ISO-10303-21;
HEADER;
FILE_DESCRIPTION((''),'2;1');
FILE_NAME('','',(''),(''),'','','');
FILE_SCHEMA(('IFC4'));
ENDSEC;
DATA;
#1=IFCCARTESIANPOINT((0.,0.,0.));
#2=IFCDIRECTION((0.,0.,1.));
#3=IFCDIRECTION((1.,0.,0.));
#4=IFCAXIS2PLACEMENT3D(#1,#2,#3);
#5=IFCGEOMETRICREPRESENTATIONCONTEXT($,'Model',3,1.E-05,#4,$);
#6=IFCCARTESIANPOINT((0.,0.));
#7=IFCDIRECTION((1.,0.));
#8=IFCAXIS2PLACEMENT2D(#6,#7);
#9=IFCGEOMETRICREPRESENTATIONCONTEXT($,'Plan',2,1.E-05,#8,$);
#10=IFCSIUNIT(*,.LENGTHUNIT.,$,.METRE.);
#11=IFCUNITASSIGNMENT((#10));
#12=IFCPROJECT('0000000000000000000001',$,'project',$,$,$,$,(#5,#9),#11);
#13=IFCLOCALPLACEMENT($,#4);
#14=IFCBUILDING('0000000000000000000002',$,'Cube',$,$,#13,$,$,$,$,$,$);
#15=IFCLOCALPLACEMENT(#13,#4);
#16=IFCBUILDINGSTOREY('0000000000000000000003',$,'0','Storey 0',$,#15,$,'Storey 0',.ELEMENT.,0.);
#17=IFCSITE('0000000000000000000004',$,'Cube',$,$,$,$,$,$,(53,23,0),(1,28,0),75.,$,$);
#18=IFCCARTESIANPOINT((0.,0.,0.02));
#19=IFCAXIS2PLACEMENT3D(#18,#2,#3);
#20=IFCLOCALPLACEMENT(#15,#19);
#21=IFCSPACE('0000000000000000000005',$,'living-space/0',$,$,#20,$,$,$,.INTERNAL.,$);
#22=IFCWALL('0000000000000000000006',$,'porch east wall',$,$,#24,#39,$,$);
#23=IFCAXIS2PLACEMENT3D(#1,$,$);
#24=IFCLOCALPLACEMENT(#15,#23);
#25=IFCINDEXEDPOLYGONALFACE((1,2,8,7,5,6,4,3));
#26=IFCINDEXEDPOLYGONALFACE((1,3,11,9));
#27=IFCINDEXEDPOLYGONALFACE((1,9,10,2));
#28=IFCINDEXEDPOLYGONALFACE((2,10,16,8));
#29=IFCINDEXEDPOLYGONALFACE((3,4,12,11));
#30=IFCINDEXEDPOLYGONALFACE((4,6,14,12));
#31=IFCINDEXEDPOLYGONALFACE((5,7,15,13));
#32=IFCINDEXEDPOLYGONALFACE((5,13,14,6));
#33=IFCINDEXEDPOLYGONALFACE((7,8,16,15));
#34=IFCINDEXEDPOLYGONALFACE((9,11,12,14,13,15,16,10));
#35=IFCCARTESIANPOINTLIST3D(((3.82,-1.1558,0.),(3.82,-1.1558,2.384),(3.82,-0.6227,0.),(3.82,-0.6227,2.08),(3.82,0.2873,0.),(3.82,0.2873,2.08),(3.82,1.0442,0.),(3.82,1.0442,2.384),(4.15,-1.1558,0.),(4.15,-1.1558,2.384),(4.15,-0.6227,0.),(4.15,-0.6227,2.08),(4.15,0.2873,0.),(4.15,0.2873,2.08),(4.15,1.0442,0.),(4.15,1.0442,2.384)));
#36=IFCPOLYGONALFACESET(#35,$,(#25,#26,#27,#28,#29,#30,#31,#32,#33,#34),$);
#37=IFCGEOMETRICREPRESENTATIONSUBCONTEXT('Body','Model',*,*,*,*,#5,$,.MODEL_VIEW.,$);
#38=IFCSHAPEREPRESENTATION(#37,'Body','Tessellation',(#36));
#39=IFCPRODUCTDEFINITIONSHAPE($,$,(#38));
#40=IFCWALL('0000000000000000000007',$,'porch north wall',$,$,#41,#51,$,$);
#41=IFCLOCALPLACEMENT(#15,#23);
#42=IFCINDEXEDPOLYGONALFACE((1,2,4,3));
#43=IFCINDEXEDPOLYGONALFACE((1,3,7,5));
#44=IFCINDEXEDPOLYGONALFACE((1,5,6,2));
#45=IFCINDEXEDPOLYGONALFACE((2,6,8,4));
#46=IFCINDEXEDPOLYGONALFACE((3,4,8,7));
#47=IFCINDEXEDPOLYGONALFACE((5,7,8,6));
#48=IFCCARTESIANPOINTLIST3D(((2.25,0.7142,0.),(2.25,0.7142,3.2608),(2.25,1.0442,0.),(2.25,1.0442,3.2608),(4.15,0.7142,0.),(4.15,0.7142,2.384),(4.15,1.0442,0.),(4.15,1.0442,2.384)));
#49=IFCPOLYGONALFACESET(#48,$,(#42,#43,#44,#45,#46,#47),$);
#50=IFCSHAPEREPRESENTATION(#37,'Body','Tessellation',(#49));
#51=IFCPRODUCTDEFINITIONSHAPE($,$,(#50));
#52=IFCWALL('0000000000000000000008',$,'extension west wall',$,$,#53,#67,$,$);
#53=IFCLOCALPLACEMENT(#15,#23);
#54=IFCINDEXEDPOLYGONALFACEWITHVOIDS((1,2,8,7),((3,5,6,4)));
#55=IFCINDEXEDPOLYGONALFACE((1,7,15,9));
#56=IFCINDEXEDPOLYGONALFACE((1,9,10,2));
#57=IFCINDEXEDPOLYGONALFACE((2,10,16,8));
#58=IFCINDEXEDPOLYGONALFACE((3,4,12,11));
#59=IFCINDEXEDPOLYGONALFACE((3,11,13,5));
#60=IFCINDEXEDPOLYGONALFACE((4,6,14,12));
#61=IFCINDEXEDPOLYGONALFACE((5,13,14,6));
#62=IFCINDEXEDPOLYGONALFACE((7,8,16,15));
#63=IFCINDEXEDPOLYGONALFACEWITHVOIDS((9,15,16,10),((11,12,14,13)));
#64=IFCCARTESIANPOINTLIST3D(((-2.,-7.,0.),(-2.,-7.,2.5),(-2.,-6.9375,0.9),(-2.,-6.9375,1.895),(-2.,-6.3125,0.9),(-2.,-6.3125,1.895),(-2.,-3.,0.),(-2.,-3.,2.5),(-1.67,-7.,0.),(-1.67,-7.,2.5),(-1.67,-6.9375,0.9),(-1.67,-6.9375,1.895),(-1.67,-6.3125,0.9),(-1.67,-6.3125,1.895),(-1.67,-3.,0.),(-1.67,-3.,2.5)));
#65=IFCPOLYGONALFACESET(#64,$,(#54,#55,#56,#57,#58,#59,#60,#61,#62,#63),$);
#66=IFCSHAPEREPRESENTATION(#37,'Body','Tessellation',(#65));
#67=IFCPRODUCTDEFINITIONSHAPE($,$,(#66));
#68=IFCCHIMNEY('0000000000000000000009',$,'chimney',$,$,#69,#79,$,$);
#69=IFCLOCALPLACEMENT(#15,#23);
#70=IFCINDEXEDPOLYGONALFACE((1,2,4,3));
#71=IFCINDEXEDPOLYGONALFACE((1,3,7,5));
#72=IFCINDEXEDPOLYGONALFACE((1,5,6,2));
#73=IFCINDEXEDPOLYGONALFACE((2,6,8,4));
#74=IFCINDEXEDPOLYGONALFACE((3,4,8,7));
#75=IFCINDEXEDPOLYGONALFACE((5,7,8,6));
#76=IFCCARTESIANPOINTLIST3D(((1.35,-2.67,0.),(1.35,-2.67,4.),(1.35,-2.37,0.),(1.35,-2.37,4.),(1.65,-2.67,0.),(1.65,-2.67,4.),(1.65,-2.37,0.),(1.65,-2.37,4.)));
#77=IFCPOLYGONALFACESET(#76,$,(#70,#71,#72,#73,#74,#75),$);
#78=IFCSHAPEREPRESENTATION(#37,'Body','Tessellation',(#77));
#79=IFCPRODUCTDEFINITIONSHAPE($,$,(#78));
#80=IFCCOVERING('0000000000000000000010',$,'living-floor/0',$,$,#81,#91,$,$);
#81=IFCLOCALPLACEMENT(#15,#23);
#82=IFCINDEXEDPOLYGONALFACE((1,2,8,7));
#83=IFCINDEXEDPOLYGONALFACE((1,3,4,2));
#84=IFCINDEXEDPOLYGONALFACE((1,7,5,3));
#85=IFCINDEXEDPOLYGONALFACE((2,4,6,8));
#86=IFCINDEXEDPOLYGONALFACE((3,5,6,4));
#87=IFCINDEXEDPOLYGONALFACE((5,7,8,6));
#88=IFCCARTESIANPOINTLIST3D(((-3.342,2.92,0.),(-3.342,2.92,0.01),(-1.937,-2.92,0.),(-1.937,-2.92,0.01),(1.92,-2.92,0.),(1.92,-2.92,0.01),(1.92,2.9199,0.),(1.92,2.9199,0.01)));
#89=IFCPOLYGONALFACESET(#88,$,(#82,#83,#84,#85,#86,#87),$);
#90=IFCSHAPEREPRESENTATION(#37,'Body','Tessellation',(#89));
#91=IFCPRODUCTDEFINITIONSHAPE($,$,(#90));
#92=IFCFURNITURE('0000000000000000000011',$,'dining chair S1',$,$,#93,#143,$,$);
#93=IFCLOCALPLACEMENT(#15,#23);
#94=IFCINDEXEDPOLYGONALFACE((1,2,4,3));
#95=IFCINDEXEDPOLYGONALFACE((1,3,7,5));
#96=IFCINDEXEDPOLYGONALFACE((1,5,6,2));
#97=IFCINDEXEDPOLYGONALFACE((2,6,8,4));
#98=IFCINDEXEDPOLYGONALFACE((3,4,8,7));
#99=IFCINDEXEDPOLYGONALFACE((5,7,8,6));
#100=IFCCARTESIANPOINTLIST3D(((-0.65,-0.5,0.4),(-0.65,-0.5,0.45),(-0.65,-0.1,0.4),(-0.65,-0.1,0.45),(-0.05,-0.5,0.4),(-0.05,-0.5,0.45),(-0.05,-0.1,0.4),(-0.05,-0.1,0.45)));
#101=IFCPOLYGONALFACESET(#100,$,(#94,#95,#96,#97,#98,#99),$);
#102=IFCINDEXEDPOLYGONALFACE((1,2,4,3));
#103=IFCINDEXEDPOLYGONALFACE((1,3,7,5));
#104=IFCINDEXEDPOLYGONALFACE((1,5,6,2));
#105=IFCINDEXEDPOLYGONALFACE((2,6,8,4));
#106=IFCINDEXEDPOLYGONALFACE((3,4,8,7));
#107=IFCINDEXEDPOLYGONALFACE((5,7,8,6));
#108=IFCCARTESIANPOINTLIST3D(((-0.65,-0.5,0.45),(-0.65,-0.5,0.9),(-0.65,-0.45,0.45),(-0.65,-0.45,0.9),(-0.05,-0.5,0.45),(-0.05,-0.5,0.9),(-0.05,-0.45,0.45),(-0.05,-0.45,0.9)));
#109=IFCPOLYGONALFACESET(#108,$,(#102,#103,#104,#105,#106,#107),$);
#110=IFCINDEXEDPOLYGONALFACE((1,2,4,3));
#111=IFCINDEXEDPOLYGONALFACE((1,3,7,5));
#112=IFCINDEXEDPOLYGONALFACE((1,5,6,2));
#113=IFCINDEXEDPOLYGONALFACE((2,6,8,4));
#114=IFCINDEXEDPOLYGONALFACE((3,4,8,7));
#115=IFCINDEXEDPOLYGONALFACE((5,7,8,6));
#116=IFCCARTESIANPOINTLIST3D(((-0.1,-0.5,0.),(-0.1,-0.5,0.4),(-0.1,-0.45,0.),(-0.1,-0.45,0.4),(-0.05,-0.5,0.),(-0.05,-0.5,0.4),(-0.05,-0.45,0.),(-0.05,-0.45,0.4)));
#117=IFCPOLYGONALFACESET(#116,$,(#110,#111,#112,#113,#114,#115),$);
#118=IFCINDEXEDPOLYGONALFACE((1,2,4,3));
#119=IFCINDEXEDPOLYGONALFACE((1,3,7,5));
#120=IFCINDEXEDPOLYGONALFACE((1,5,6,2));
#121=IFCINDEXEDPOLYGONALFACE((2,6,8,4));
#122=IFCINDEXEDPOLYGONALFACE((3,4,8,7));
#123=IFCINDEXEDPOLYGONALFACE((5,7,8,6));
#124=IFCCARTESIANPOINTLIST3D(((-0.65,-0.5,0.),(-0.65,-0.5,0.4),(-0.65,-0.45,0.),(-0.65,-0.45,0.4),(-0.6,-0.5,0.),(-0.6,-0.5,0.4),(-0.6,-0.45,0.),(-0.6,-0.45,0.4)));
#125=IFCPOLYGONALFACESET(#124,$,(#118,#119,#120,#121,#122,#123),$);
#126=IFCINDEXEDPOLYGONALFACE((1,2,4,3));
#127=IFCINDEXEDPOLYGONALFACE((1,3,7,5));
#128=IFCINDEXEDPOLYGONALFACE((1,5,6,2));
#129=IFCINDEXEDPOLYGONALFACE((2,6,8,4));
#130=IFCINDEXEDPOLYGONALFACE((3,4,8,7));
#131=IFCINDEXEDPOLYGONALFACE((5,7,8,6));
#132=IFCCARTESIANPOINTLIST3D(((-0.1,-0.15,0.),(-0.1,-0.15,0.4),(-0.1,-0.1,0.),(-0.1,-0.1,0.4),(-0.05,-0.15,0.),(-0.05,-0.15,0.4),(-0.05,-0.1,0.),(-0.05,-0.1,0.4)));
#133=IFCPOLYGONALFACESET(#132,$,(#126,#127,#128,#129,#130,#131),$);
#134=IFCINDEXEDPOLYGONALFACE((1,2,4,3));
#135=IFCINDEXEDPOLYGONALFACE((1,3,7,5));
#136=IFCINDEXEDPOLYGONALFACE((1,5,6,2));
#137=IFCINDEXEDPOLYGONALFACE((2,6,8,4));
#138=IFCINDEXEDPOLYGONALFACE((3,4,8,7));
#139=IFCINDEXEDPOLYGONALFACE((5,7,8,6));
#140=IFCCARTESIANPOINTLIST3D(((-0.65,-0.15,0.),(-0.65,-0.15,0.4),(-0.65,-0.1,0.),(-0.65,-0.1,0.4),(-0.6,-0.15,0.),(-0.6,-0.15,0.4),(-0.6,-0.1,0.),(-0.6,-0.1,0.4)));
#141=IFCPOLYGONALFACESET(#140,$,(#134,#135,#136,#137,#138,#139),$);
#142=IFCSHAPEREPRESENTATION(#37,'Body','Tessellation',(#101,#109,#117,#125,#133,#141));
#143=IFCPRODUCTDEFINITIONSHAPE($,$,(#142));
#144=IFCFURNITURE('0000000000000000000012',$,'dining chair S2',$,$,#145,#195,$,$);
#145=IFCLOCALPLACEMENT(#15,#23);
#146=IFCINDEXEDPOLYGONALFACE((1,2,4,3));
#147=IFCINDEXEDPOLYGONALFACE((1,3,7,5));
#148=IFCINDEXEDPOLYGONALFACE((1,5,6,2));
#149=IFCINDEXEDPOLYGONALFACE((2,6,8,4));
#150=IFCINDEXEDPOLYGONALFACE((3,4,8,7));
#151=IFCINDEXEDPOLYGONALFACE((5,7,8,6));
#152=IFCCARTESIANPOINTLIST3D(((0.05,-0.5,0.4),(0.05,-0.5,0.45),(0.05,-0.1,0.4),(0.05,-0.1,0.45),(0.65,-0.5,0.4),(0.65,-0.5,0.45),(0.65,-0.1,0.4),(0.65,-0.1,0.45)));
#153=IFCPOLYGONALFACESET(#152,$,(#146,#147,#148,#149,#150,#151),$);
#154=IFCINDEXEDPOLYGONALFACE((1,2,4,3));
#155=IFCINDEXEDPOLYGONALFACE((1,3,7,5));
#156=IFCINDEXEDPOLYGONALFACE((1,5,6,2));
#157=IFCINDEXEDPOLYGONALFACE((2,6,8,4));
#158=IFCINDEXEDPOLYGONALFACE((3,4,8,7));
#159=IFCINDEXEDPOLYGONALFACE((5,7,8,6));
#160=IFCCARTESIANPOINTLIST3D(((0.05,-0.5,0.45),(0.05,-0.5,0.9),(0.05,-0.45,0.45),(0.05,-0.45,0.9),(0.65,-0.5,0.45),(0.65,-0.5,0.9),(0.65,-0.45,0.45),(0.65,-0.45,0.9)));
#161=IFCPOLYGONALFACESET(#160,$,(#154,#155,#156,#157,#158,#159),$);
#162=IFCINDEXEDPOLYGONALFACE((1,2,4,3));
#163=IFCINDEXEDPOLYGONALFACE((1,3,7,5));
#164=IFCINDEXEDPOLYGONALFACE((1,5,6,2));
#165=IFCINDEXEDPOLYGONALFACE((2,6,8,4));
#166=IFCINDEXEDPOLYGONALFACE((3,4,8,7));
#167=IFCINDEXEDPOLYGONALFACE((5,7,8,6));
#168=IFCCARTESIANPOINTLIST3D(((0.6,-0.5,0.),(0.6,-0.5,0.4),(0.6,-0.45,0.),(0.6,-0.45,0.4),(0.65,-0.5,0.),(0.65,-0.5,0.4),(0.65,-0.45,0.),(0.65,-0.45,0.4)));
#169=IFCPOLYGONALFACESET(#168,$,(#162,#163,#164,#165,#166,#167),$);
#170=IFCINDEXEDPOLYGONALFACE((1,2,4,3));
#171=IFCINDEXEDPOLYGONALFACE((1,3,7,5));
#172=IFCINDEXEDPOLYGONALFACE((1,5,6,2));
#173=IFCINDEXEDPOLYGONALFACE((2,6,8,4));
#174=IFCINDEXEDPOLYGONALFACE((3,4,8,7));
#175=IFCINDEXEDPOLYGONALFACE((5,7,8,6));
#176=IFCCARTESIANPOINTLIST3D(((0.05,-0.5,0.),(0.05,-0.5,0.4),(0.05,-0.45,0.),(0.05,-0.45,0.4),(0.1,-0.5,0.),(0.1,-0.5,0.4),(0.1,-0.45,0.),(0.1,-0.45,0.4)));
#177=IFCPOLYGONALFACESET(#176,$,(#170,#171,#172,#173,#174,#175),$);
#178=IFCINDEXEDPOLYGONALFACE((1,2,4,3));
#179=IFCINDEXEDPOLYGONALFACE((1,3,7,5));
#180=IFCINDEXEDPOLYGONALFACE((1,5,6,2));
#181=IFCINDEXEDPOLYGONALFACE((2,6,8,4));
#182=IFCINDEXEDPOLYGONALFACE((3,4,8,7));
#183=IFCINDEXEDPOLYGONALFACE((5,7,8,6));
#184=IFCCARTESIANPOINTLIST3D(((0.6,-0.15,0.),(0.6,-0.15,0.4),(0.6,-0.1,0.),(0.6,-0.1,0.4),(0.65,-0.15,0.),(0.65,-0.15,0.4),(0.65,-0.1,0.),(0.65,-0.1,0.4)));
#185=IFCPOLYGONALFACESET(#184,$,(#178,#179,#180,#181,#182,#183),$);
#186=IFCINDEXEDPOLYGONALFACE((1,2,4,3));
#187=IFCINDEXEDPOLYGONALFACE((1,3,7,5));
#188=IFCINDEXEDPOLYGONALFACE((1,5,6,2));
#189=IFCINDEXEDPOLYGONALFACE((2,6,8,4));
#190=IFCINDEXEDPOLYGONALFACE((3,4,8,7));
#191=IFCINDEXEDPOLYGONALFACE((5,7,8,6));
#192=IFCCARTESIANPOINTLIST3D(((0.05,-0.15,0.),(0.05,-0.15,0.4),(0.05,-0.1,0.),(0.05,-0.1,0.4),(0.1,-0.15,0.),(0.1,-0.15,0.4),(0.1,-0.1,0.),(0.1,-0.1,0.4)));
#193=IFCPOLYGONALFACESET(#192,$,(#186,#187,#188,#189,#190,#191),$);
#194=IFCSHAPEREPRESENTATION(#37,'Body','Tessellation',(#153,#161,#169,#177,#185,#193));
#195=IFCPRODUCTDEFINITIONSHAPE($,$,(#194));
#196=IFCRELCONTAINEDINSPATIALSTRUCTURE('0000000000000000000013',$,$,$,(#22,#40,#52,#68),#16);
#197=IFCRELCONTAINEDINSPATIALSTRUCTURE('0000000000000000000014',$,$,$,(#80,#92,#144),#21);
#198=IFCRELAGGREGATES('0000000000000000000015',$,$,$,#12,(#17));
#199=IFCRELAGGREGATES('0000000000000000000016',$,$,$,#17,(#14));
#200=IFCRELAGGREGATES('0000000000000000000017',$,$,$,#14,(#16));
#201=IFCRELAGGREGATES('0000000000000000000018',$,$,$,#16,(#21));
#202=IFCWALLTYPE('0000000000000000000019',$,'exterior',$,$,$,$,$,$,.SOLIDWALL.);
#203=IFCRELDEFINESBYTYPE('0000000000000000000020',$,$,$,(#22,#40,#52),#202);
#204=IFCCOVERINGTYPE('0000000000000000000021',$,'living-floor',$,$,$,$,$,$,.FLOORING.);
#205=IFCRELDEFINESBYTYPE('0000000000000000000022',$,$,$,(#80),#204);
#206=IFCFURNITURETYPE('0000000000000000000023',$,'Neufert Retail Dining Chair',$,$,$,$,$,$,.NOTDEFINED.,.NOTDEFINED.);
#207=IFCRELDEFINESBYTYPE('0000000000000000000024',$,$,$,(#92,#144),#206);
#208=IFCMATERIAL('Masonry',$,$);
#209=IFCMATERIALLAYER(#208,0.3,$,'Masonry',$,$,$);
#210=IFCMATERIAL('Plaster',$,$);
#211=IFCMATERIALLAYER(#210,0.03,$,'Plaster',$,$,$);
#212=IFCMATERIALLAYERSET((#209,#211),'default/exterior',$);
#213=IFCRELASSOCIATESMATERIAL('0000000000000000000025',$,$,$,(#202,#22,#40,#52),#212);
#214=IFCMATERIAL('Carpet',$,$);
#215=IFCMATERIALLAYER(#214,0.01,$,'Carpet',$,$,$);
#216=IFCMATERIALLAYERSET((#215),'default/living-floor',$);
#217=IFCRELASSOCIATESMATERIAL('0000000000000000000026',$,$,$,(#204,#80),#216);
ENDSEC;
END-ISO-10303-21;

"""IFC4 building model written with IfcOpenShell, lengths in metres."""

from ifc_helpers import new_model, entity, si_unit, frame, origin_with_axes, origin_2d_with_axis, place, context, subcontext, project, spatial, polyline, line, indexed_curve, outline, extrude, clip, halfspace, shape, source, transform, mapped, material, layer, layer_set, layer_usage, type_object, type_shapes, element, save


model = new_model("IFC4")

# Units and contexts
model_context = context("Model", 3, precision=1e-05, world=origin_with_axes())
plan_context = context("Plan", 2, precision=1e-05, world=origin_2d_with_axis())
body_context_1 = subcontext(model_context, "Body", "Model", "MODEL_VIEW")
body_context_2 = subcontext(plan_context, "Body", "Plan", "PLAN_VIEW")
ifc_project = project(units=[si_unit("LENGTHUNIT", "METRE")], contexts=[model_context, plan_context])

# Site, building, storey
site = spatial("IfcSite", under=ifc_project, Name="Cube", RefLatitude=(53, 23, 0), RefLongitude=(1, 28, 0), RefElevation=75.0)
building_placement = place(None, origin_with_axes())
building = spatial("IfcBuilding", under=site, at=building_placement, Name="Cube")
storey_placement = place(building_placement, origin_with_axes())
storey = spatial("IfcBuildingStorey", under=building, at=storey_placement, Name="0", Description="Storey 0", LongName="Storey 0", CompositionType="ELEMENT", Elevation=0.0)

# Shared definitions
ifc_material_1 = material(Name="Masonry")
ifc_layer_1 = layer(ifc_material_1, 0.3, Name="Masonry")
ifc_material_2 = material(Name="Plaster")
ifc_layer_2 = layer(ifc_material_2, 0.03, Name="Plaster")
ifc_layer_set_1 = layer_set([ifc_layer_1, ifc_layer_2], Name="default/exterior")
wall_type = type_object("IfcWallType", Name="exterior", PredefinedType="SOLIDWALL", material=ifc_layer_set_1)

# Wall, opening
ifc_layer_usage_1 = layer_usage(ifc_layer_set_1, "AXIS2", "POSITIVE", 0.0)
wall_1_placement = place(storey_placement, frame((4.15, -1.1558, 0.0), z_axis=(0.0, 0.0, 1.0), x_axis=(0.0, 1.0, 0.0)))
wall_1 = element("IfcWall", 1, at=wall_1_placement, inside=storey, type_object=wall_type, material=ifc_layer_usage_1, Name="porch east wall", context=body_context_1, shape_type="SweptSolid", body=[
    extrude(outline(indexed_curve([(0.0, 0.0), (0.0, 0.33), (2.2, 0.33), (2.2, 0.0), (0.0, 0.0)], self_intersect=False)), origin_with_axes(), (0.0, 0.0, 1.0), 2.384),
])
shared_shape_1 = source(origin_with_axes(), body_context_1, "Body", "SweptSolid", [
    extrude(outline(indexed_curve([(0.0, 0.0), (0.91, 0.0), (0.91, 2.08), (0.0, 2.08)], segments=[line(1, 2, 3, 4, 1)])), frame((0.0, -0.6, 0.0), z_axis=(0.0, -1.0, 0.0), x_axis=(1.0, 0.0, 0.0)), (0.0, 0.0, -1.0), 1.2),
])
opening_1_placement = place(wall_1_placement, frame((0.5331, 0.0, 0.0), z_axis=(0.0, 0.0, 1.0), x_axis=(1.0, 0.0, 0.0)))
element("IfcOpeningElement", 2, at=opening_1_placement, cuts=wall_1, PredefinedType="OPENING", context=body_context_1, shape_type="MappedRepresentation", body=[
    mapped(shared_shape_1, transform((0.0, 0.0, 0.0), x_axis=(1.0, 0.0, 0.0), y_axis=(0.0, 1.0, 0.0), z_axis=(0.0, 0.0, 1.0), scale=1.0)),
])

# Wall
ifc_layer_usage_2 = layer_usage(ifc_layer_set_1, "AXIS2", "POSITIVE", 0.0)
wall_2_placement = place(storey_placement, frame((4.15, 1.0442, 0.0), z_axis=(0.0, 0.0, 1.0), x_axis=(-1.0, 0.0, 0.0)))
element("IfcWall", 3, at=wall_2_placement, inside=storey, type_object=wall_type, material=ifc_layer_usage_2, Name="porch north wall", context=body_context_1, shape_type="Clipping", body=[
    clip(extrude(outline(indexed_curve([(0.0, 0.0), (0.0, 0.33), (1.9, 0.33), (1.9, 0.0), (0.0, 0.0)], self_intersect=False)), origin_with_axes(), (0.0, 0.0, 1.0), 3.5), halfspace(frame((0.0, 0.0, 2.384), z_axis=(-0.419, 0.0, 0.908), x_axis=(0.0, -1.0, 0.0)), False)),
])

# Wall, opening
ifc_layer_usage_3 = layer_usage(ifc_layer_set_1, "AXIS2", "POSITIVE", 0.0)
wall_3_placement = place(storey_placement, frame((-2.0, -3.0, 0.0), z_axis=(0.0, 0.0, 1.0), x_axis=(0.0, -1.0, 0.0)))
wall_3 = element("IfcWall", 4, at=wall_3_placement, inside=storey, type_object=wall_type, material=ifc_layer_usage_3, Name="extension west wall", context=body_context_1, shape_type="SweptSolid", body=[
    extrude(outline(indexed_curve([(0.0, 0.0), (0.0, 0.33), (4.0, 0.33), (4.0, 0.0), (0.0, 0.0)], self_intersect=False)), origin_with_axes(), (0.0, 0.0, 1.0), 2.5),
])
opening_2_placement = place(wall_3_placement, frame((3.3125, 0.0, 0.9), z_axis=(0.0, 0.0, 1.0), x_axis=(1.0, 0.0, 0.0)))
element("IfcOpeningElement", 5, at=opening_2_placement, cuts=wall_3, PredefinedType="OPENING", context=body_context_1, shape_type="SweptSolid", body=[
    extrude(outline(indexed_curve([(0.0, 0.0), (0.0, 0.5), (0.625, 0.5), (0.625, 0.0), (0.0, 0.0)], self_intersect=False)), origin_with_axes(), (0.0, 0.0, 1.0), 0.995),
])

# Chimney
chimney_placement = place(storey_placement, frame((1.35, -2.67, 0.0), z_axis=(0.0, 0.0, 1.0), x_axis=(1.0, 0.0, 0.0)))
element("IfcChimney", 6, at=chimney_placement, inside=storey, Name="chimney", context=body_context_1, shape_type="SweptSolid", body=[
    extrude(outline(indexed_curve([(0.0, 0.0), (0.3, 0.0), (0.3, 0.3), (0.0, 0.3)])), None, (0.0, 0.0, 1.0), 4.0),
])

# Shared definitions
space_placement = place(storey_placement, frame((0.0, 0.0, 0.02), z_axis=(0.0, 0.0, 1.0), x_axis=(1.0, 0.0, 0.0)))
space = spatial("IfcSpace", under=storey, at=space_placement, Name="living-space/0", PredefinedType="INTERNAL")

# Covering
ifc_material_3 = material(Name="Carpet")
ifc_layer_3 = layer(ifc_material_3, 0.01, Name="Carpet")
ifc_layer_set_2 = layer_set([ifc_layer_3], Name="default/living-floor")
ifc_layer_usage_4 = layer_usage(ifc_layer_set_2, "AXIS3", "POSITIVE", 0.0)
covering_type = type_object("IfcCoveringType", Name="living-floor", PredefinedType="FLOORING", material=ifc_layer_set_2)
covering_placement = place(space_placement, frame((0.0, 0.0, -0.02), z_axis=(0.0, 0.0, 1.0), x_axis=(1.0, 0.0, 0.0)))
element("IfcCovering", 7, at=covering_placement, inside=space, type_object=covering_type, material=ifc_layer_usage_4, Name="living-floor/0", context=body_context_1, shape_type="SweptSolid", body=[
    extrude(outline(polyline([(1.92, 2.9199), (-3.342, 2.92), (-1.937, -2.92), (1.92, -2.92), (1.92, 2.9199)])), origin_with_axes(), (0.0, 0.0, 1.0), 0.01),
])

# Furniture
furniture_type_1 = type_object("IfcFurnitureType", Name="Neufert Retail Dining Chair", AssemblyPlace="NOTDEFINED", PredefinedType="NOTDEFINED")
shared_shape_2 = source(origin_with_axes(), body_context_1, "Body", "SweptSolid", [
    extrude(outline(indexed_curve([(-0.3, 0.0), (0.3, 0.0), (0.3, -0.4), (-0.3, -0.4)], segments=[line(1, 2, 3, 4, 1)])), frame((0.0, 0.0, 0.45), z_axis=(0.0, 0.0, 1.0), x_axis=(1.0, 0.0, 0.0)), (0.0, 0.0, -1.0), 0.05),
    extrude(outline(indexed_curve([(-0.3, 0.0), (0.3, 0.0), (0.3, -0.05), (-0.3, -0.05)], segments=[line(1, 2, 3, 4, 1)])), frame((0.0, 0.0, 0.9), z_axis=(0.0, 0.0, 1.0), x_axis=(1.0, 0.0, 0.0)), (0.0, 0.0, -1.0), 0.45),
    extrude(outline(indexed_curve([(-0.3, 0.0), (-0.25, 0.0), (-0.25, -0.05), (-0.3, -0.05)], segments=[line(1, 2, 3, 4, 1)])), origin_with_axes(), (0.0, 0.0, 1.0), 0.4),
    extrude(outline(indexed_curve([(0.3, 0.0), (0.25, 0.0), (0.25, -0.05), (0.3, -0.05)], segments=[line(1, 2, 3, 4, 1)])), origin_with_axes(), (0.0, 0.0, 1.0), 0.4),
    extrude(outline(indexed_curve([(-0.3, -0.4), (-0.25, -0.4), (-0.25, -0.35), (-0.3, -0.35)], segments=[line(1, 2, 3, 4, 1)])), origin_with_axes(), (0.0, 0.0, 1.0), 0.4),
    extrude(outline(indexed_curve([(0.3, -0.4), (0.25, -0.4), (0.25, -0.35), (0.3, -0.35)], segments=[line(1, 2, 3, 4, 1)])), origin_with_axes(), (0.0, 0.0, 1.0), 0.4),
])
shared_shape_3 = source(origin_with_axes(), body_context_2, "Body", "Curve2D", [
    entity("IfcIndexedPolyCurve", entity("IfcCartesianPointList2D", [[-0.3, -0.4], [0.3, -0.4]])),
    entity("IfcIndexedPolyCurve", entity("IfcCartesianPointList2D", [[-0.3, -0.4], [-0.3, -0.3], [-0.2121, -0.0879], [0.0, 0.0], [0.2121, -0.0879], [0.3, -0.3], [0.3, -0.4]]), [entity("IfcLineIndex", [1, 2]), entity("IfcArcIndex", [2, 3, 4]), entity("IfcArcIndex", [4, 5, 6]), entity("IfcLineIndex", [6, 7])]),
    entity("IfcIndexedPolyCurve", entity("IfcCartesianPointList2D", [[-0.26, -0.4], [-0.26, -0.3], [-0.1838, -0.1162], [0.0, -0.04], [0.1838, -0.1162], [0.26, -0.3], [0.26, -0.4]]), [entity("IfcLineIndex", [1, 2]), entity("IfcArcIndex", [2, 3, 4]), entity("IfcArcIndex", [4, 5, 6]), entity("IfcLineIndex", [6, 7])]),
])
type_shapes(furniture_type_1, [shared_shape_2, shared_shape_3])
for number, where, z_axis, x_axis, name in (
    (8, (-0.35, -0.5, -0.02), (0.0, 0.0, 1.0), (-1.0, 0.0, 0.0), "dining chair S1"),
    (9, (0.35, -0.5, -0.02), (0.0, 0.0, 1.0), (-1.0, 0.0, 0.0), "dining chair S2"),
):
    element("IfcFurniture", number, at=place(space_placement, frame(where, z_axis=z_axis, x_axis=x_axis)), inside=space, type_object=furniture_type_1, Name=name, shapes=[
        shape(body_context_1, "Body", "MappedRepresentation", [mapped(shared_shape_2, transform((0.0, 0.0, 0.0), x_axis=(1.0, 0.0, 0.0), y_axis=(0.0, 1.0, 0.0), z_axis=(0.0, 0.0, 1.0), scale=1.0))]),
        shape(body_context_2, "Body", "MappedRepresentation", [mapped(shared_shape_3, transform((0.0, 0.0, 0.0), x_axis=(1.0, 0.0, 0.0), y_axis=(0.0, 1.0, 0.0), z_axis=(0.0, 0.0, 1.0), scale=1.0))]),
    ])

save(model, "model.ifc")
